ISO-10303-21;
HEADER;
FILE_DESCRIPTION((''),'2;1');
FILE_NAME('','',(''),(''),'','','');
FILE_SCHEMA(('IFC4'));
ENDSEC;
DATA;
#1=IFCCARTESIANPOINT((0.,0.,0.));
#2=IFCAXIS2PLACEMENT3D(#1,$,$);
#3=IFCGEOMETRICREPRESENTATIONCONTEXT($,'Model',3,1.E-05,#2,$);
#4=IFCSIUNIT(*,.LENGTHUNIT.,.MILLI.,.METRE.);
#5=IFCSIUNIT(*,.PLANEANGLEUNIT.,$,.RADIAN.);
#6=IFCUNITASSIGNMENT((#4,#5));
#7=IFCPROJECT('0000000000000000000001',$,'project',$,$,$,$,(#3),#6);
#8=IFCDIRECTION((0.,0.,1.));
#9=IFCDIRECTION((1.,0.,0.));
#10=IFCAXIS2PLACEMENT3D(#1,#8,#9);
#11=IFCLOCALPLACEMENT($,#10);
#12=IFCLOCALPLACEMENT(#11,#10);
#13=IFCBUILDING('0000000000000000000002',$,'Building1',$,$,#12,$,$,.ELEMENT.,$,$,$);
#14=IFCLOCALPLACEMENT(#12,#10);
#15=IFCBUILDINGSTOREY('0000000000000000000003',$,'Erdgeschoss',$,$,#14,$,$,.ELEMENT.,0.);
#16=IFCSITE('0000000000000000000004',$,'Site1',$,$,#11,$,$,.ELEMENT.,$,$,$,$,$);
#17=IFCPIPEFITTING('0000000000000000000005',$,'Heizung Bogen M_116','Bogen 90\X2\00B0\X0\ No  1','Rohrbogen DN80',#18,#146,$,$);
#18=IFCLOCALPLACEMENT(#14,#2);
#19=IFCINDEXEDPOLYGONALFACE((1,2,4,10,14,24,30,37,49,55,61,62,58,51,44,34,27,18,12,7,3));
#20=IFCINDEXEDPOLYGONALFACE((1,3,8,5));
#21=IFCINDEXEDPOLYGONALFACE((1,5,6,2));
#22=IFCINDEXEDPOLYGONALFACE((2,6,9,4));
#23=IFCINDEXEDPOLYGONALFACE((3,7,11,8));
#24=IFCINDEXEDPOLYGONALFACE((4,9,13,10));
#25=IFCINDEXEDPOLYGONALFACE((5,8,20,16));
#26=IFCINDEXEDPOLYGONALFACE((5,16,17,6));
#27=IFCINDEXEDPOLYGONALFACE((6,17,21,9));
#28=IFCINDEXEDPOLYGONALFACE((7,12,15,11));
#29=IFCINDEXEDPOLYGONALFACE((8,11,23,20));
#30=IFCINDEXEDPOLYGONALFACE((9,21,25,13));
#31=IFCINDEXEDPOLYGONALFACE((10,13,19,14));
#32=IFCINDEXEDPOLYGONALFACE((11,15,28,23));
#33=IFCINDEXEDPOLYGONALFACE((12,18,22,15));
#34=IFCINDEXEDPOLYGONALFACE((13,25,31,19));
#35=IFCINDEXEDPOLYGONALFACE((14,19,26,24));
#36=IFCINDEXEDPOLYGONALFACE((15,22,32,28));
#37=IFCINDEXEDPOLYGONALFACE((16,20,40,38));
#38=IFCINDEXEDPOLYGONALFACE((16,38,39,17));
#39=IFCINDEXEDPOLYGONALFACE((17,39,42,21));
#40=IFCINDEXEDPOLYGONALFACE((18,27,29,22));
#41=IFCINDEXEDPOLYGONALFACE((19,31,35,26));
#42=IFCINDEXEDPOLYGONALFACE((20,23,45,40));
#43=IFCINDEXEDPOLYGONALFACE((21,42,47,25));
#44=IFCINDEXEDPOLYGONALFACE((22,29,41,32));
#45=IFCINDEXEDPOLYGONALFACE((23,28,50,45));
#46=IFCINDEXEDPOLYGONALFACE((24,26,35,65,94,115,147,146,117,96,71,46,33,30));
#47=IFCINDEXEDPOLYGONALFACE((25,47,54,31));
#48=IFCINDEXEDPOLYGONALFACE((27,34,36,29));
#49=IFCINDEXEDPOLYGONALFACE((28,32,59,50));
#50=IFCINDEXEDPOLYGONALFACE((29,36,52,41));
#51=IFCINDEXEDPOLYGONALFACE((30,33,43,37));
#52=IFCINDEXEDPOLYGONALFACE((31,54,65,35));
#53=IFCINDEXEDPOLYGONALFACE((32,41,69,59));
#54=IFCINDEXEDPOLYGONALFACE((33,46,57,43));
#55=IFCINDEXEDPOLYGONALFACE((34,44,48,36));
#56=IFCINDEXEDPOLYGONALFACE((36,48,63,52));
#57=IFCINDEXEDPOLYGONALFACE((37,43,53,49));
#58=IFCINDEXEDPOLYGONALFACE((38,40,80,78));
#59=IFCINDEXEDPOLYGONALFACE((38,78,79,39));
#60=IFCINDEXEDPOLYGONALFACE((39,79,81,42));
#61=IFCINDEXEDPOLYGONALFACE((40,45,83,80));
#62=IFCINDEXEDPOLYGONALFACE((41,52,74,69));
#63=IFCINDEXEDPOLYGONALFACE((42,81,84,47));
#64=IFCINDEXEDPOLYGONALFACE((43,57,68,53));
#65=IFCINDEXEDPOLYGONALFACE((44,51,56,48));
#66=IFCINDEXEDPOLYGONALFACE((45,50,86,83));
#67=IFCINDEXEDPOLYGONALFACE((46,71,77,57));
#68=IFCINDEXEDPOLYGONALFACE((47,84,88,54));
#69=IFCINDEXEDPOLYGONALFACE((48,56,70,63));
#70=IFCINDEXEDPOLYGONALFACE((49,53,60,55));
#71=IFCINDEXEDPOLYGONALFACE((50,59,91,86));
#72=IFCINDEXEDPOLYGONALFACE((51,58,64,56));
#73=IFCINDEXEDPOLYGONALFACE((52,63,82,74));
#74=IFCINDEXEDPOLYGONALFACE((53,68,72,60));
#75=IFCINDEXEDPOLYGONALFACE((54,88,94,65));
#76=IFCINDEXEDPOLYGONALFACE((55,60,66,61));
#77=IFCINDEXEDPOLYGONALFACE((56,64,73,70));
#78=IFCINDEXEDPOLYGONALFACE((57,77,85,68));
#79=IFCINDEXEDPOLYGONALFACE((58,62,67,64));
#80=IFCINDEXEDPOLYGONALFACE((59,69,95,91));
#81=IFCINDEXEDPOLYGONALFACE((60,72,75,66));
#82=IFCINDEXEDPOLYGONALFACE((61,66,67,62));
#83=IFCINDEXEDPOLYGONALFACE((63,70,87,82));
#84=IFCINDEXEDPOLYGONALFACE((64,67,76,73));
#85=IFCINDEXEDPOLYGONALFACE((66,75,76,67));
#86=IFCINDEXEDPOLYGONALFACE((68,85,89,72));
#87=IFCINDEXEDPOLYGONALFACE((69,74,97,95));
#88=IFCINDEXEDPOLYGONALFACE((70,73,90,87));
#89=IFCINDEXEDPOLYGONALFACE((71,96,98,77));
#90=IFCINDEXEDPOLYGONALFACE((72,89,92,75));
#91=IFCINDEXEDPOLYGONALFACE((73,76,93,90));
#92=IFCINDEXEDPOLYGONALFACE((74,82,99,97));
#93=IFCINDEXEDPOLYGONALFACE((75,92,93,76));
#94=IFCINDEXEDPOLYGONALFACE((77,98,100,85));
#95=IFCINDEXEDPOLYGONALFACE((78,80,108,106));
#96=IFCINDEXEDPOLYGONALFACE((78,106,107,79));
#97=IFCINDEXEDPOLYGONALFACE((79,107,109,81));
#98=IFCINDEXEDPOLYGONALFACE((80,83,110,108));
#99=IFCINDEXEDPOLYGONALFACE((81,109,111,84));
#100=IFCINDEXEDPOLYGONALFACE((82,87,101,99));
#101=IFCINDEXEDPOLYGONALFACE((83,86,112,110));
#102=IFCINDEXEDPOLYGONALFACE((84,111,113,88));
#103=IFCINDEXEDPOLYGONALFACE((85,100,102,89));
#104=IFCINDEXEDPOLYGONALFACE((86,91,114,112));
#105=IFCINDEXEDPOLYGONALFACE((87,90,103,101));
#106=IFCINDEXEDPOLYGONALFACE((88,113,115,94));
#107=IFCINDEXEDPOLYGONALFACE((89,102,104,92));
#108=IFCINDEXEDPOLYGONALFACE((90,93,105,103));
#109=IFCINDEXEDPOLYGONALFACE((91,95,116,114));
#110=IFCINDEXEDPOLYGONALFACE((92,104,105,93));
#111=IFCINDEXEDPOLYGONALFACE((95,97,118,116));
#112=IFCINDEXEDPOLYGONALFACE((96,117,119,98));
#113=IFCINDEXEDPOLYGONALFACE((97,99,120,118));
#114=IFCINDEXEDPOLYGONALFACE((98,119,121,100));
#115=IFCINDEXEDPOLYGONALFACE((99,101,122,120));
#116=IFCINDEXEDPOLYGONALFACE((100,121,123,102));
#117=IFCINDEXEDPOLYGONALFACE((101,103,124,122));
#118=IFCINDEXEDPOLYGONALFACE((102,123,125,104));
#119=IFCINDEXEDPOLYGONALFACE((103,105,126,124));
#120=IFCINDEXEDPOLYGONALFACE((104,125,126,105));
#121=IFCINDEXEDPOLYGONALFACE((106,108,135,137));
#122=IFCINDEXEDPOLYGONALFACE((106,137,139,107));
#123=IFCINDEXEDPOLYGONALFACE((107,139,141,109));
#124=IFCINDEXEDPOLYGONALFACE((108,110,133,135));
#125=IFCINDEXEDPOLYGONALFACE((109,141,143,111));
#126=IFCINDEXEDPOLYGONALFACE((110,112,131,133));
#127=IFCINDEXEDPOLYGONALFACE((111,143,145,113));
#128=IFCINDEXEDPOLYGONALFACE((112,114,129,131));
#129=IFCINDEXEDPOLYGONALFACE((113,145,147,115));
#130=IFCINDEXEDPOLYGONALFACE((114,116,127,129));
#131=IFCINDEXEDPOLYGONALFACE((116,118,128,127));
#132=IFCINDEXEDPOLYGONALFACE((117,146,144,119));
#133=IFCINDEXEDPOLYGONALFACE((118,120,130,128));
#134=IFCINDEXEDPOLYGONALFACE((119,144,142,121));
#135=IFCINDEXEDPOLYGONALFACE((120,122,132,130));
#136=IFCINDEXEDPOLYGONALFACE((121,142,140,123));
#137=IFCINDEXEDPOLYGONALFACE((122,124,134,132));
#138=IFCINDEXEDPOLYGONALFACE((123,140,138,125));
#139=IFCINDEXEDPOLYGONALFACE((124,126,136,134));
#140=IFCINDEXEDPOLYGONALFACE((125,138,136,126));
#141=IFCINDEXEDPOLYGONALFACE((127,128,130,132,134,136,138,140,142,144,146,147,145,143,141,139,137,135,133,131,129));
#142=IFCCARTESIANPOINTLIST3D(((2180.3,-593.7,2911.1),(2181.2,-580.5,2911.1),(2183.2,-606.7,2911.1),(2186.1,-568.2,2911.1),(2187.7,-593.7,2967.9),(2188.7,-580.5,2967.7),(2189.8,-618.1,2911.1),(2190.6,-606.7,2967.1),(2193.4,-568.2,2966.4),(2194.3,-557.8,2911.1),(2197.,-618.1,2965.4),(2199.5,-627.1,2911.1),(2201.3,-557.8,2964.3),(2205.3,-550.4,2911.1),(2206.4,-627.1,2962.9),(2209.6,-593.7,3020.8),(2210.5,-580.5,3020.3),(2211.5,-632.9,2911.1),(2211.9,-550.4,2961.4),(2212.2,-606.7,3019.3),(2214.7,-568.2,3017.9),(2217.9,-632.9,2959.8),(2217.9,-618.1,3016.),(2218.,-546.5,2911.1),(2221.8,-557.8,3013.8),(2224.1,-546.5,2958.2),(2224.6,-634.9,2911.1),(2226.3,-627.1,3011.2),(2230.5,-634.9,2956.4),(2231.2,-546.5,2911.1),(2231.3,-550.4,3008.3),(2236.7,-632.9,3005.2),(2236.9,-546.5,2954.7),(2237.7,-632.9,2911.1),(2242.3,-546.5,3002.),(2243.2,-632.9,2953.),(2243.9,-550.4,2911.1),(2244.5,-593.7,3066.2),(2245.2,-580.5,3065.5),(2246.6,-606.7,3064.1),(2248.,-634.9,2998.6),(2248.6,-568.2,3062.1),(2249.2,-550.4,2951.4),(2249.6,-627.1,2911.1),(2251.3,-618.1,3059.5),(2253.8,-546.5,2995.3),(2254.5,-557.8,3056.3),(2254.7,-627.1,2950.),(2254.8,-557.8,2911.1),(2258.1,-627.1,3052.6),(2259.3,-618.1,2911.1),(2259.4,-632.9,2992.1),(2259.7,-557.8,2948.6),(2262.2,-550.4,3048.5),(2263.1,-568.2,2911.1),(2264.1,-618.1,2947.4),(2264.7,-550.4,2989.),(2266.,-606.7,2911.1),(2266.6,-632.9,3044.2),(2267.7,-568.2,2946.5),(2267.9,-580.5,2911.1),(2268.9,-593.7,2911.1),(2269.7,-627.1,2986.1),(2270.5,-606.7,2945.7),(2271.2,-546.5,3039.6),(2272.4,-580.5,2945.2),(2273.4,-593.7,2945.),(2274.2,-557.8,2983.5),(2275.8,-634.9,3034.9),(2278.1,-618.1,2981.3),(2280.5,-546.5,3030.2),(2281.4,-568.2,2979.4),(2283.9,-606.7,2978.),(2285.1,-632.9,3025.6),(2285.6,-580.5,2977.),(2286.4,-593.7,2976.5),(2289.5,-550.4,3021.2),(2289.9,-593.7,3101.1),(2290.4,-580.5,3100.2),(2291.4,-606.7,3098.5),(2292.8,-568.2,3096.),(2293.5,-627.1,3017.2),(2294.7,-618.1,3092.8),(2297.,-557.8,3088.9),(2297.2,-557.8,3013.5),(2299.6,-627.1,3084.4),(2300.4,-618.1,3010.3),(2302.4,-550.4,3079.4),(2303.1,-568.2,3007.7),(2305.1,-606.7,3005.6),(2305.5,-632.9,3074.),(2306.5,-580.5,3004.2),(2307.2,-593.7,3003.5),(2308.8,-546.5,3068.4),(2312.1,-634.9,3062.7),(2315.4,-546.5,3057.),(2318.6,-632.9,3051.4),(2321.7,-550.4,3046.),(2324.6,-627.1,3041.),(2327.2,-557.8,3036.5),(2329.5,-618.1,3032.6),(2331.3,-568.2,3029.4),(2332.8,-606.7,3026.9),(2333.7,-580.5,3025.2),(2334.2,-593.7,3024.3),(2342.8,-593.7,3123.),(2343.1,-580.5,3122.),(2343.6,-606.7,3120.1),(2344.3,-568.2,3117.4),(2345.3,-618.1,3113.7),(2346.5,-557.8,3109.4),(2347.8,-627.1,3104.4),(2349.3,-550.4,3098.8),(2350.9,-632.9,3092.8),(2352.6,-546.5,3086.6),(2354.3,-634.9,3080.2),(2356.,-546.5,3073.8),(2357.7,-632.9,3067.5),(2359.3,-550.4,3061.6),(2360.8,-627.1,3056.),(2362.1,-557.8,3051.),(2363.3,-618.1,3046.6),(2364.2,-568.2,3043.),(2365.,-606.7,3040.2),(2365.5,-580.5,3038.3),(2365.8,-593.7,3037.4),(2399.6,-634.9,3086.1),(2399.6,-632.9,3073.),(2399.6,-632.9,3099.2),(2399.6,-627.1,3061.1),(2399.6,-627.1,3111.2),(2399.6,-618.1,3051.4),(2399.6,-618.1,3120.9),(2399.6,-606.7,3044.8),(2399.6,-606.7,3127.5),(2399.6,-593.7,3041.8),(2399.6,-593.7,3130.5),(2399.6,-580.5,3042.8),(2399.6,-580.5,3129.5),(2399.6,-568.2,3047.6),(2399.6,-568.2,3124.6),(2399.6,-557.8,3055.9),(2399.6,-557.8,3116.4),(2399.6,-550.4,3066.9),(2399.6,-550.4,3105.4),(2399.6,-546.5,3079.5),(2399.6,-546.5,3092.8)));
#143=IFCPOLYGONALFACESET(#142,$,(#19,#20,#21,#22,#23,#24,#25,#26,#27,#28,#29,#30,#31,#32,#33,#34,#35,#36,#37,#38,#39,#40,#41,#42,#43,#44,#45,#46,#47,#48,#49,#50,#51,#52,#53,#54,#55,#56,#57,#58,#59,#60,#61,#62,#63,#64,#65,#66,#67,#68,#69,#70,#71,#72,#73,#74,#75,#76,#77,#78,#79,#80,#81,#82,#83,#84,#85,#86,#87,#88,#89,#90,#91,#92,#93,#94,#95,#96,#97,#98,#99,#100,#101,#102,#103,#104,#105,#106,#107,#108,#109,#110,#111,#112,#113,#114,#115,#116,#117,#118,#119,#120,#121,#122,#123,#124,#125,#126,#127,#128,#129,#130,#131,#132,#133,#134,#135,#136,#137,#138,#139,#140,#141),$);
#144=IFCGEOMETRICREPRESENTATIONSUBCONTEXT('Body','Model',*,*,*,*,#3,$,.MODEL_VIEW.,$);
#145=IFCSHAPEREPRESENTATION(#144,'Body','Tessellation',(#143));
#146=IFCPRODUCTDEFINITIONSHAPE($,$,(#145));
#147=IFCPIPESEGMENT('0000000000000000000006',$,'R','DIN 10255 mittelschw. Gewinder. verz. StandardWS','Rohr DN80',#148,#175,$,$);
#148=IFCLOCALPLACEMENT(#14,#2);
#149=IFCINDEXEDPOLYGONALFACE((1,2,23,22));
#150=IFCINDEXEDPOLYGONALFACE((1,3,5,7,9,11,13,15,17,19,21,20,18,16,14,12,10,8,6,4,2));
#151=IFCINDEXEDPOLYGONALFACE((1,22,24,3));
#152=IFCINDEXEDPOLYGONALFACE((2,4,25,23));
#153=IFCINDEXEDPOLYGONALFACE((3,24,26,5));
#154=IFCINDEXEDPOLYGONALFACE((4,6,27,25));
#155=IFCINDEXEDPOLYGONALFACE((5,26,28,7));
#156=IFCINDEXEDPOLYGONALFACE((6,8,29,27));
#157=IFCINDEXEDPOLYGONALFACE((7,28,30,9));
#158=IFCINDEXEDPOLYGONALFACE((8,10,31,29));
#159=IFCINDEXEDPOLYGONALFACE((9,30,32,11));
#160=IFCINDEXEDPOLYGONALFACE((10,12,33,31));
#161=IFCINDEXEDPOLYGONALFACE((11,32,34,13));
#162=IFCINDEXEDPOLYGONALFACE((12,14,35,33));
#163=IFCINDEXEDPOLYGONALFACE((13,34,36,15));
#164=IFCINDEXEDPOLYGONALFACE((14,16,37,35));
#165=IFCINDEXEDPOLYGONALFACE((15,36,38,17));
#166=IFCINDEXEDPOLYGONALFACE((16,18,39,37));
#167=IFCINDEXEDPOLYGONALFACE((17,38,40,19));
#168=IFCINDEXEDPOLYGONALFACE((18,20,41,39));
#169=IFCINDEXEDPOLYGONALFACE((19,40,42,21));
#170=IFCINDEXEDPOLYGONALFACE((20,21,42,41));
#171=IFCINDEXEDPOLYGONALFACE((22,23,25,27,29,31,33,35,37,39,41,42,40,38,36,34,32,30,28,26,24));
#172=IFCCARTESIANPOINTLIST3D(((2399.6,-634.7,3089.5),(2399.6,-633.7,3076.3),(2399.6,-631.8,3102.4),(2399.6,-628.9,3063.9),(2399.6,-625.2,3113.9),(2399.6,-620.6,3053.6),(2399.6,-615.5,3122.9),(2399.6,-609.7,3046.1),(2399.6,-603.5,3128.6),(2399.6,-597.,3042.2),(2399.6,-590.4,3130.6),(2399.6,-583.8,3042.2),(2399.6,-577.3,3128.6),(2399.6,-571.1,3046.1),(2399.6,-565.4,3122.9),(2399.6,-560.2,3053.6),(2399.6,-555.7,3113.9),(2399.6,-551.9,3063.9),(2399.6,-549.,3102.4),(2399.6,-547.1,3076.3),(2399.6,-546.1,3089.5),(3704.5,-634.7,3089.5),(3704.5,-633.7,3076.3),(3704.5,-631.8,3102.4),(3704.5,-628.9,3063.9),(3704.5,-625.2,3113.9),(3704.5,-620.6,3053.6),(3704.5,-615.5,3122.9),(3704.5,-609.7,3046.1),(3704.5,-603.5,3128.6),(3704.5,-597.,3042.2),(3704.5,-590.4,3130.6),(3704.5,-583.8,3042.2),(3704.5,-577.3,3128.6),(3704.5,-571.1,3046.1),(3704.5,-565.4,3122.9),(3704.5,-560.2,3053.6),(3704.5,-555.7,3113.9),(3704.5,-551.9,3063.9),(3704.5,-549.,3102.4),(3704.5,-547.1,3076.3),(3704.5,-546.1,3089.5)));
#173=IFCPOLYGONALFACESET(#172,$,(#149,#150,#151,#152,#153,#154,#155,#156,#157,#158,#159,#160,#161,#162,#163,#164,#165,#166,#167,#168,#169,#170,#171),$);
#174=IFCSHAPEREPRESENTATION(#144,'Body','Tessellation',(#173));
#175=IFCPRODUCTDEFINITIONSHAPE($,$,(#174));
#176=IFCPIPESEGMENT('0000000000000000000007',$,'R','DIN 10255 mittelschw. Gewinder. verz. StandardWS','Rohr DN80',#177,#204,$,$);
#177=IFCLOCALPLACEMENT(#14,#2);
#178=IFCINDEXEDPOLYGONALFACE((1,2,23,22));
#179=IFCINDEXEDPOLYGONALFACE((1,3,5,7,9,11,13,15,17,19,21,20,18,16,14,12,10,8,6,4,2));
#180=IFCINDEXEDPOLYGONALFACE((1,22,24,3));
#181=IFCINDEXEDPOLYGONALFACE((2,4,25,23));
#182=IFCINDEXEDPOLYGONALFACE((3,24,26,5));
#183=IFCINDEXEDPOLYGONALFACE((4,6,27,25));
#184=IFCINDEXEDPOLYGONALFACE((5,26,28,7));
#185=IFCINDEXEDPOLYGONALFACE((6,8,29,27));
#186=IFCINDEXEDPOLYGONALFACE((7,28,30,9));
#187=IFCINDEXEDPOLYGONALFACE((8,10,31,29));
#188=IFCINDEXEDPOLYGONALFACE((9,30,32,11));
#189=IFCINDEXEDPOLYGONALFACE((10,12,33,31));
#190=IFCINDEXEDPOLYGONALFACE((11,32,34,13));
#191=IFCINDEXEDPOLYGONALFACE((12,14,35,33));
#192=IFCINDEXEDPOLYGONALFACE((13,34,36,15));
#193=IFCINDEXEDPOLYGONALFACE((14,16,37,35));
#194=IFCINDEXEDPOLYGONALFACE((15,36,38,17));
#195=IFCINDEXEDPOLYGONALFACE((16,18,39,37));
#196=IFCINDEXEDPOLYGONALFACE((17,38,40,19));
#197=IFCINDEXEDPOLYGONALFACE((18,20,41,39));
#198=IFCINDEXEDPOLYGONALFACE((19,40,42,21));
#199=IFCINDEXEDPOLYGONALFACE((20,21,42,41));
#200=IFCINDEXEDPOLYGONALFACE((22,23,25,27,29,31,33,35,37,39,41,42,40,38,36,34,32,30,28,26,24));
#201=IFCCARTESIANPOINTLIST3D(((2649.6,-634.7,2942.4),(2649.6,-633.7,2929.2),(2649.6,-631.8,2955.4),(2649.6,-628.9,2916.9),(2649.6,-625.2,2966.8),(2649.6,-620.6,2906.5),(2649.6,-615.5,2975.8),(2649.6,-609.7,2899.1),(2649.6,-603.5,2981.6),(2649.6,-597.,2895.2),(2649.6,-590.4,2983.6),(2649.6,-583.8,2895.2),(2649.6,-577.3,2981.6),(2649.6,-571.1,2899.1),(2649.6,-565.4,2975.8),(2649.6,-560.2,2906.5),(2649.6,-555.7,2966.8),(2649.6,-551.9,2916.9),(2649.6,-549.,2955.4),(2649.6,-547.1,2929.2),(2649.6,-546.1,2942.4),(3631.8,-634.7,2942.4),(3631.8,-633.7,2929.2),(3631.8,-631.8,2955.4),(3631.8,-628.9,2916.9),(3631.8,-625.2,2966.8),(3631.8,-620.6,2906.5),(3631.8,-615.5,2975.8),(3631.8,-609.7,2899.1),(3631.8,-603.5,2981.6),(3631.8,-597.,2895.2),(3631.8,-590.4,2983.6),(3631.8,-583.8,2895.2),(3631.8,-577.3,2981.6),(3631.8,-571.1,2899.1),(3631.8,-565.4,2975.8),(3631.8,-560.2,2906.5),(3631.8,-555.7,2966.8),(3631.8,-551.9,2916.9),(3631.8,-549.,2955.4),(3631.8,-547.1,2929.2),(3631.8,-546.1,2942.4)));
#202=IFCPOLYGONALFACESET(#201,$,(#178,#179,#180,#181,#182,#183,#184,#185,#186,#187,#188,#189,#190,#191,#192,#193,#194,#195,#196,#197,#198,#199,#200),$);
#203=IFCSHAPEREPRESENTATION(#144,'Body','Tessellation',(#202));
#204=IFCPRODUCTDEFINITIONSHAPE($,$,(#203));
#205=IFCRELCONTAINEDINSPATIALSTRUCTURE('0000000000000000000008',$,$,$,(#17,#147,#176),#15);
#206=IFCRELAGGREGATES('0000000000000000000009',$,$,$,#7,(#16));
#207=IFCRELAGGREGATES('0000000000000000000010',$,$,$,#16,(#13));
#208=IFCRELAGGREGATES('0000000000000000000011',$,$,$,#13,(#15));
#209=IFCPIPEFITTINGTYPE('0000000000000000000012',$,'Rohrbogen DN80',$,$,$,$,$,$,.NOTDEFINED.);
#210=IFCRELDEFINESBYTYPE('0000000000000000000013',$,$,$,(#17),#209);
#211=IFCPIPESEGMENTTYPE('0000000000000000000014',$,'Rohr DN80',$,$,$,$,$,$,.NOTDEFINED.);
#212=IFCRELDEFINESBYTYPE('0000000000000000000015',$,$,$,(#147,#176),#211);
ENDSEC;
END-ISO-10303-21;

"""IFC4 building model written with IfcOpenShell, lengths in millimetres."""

from ifc_helpers import new_model, entity, si_unit, frame, origin, origin_with_axes, origin_2d_with_axis, place, context, subcontext, project, spatial, circle, extrude, source, transform, mapped, type_object, element, save


model = new_model("IFC4")

# Units and contexts
model_context = context("Model", 3, precision=1e-05, world=origin())
body_context = subcontext(model_context, "Body", "Model", "MODEL_VIEW")
ifc_project = project(units=[si_unit("LENGTHUNIT", "METRE", prefix="MILLI"), si_unit("PLANEANGLEUNIT", "RADIAN")], contexts=[model_context])

# Site, building, storey
site_placement = place(None, origin_with_axes())
site = spatial("IfcSite", under=ifc_project, at=site_placement, Name="Site1", CompositionType="ELEMENT")
building_placement = place(site_placement, origin_with_axes())
building = spatial("IfcBuilding", under=site, at=building_placement, Name="Building1", CompositionType="ELEMENT")
storey_placement = place(building_placement, origin_with_axes())
storey = spatial("IfcBuildingStorey", under=building, at=storey_placement, Name="Erdgeschoss", CompositionType="ELEMENT", Elevation=0.0)

# Pipe fitting
pipe_fitting_type_1 = type_object("IfcPipeFittingType", Name="Rohrbogen DN80", PredefinedType="NOTDEFINED")
shared_shape_1 = source(origin_with_axes(), body_context, "Body", "SolidModel", [
    entity("IfcRevolvedAreaSolid", entity("IfcCircleProfileDef", "AREA", None, entity("IfcAxis2Placement2D", entity("IfcCartesianPoint", [0.0, 0.0]), entity("IfcDirection", [1.0, 0.0])), 44.5), entity("IfcAxis2Placement3D", entity("IfcCartesianPoint", [109.7, -65.3, 0.0]), entity("IfcDirection", [-1.0, 0.0, 0.0]), entity("IfcDirection", [0.0, 0.0, 1.0])), entity("IfcAxis1Placement", entity("IfcCartesianPoint", [0.0, 175.0, 0.0]), entity("IfcDirection", [-1.0, 0.0, 0.0])), 1.570796),
])
pipe_fitting_1_placement = place(storey_placement, frame((2289.9, -590.4, 3020.9), z_axis=(0.0, 0.0, 1.0), x_axis=(1.0, 0.0, 0.0)))
element("IfcPipeFitting", 1, at=pipe_fitting_1_placement, inside=storey, type_object=pipe_fitting_type_1, Name="Heizung Bogen M_116", Description="Bogen 90° No  1", ObjectType="Rohrbogen DN80", context=body_context, shape_type="MappedRepresentation", body=[
    mapped(shared_shape_1, transform((0.0, 0.0, 0.0), x_axis=(0.0, 0.0, -1.0), y_axis=(1.0, 0.0, 0.0), z_axis=(0.0, -1.0, 0.0), scale=1.0)),
])

# Pipe segments
pipe_segment_type_1 = type_object("IfcPipeSegmentType", Name="Rohr DN80", PredefinedType="NOTDEFINED")
pipe_segment_1_placement = place(storey_placement, frame((3052.0, -590.3, 3086.1), z_axis=(0.0, 0.0, 1.0), x_axis=(1.0, 0.0, 0.0)))
element("IfcPipeSegment", 2, at=pipe_segment_1_placement, inside=storey, type_object=pipe_segment_type_1, Name="R", Description="DIN 10255 mittelschw. Gewinder. verz. StandardWS", ObjectType="Rohr DN80", context=body_context, shape_type="SolidModel", body=[
    extrude(circle(Radius=44.5, at=origin_2d_with_axis()), frame((-652.5, -0.2, 0.0), z_axis=(1.0, 0.0, 0.0), x_axis=(0.0, 0.0, 1.0)), (0.0, 0.0, 1.0), 1304.9),
])
pipe_segment_2_placement = place(storey_placement, frame((3140.7, -590.3, 2939.1), z_axis=(0.0, 0.0, 1.0), x_axis=(1.0, 0.0, 0.0)))
element("IfcPipeSegment", 3, at=pipe_segment_2_placement, inside=storey, type_object=pipe_segment_type_1, Name="R", Description="DIN 10255 mittelschw. Gewinder. verz. StandardWS", ObjectType="Rohr DN80", context=body_context, shape_type="SolidModel", body=[
    extrude(circle(Radius=44.5, at=origin_2d_with_axis()), frame((-491.1, -0.2, 0.0), z_axis=(1.0, 0.0, 0.0), x_axis=(0.0, 0.0, 1.0)), (0.0, 0.0, 1.0), 982.2),
])

save(model, "model.ifc")
